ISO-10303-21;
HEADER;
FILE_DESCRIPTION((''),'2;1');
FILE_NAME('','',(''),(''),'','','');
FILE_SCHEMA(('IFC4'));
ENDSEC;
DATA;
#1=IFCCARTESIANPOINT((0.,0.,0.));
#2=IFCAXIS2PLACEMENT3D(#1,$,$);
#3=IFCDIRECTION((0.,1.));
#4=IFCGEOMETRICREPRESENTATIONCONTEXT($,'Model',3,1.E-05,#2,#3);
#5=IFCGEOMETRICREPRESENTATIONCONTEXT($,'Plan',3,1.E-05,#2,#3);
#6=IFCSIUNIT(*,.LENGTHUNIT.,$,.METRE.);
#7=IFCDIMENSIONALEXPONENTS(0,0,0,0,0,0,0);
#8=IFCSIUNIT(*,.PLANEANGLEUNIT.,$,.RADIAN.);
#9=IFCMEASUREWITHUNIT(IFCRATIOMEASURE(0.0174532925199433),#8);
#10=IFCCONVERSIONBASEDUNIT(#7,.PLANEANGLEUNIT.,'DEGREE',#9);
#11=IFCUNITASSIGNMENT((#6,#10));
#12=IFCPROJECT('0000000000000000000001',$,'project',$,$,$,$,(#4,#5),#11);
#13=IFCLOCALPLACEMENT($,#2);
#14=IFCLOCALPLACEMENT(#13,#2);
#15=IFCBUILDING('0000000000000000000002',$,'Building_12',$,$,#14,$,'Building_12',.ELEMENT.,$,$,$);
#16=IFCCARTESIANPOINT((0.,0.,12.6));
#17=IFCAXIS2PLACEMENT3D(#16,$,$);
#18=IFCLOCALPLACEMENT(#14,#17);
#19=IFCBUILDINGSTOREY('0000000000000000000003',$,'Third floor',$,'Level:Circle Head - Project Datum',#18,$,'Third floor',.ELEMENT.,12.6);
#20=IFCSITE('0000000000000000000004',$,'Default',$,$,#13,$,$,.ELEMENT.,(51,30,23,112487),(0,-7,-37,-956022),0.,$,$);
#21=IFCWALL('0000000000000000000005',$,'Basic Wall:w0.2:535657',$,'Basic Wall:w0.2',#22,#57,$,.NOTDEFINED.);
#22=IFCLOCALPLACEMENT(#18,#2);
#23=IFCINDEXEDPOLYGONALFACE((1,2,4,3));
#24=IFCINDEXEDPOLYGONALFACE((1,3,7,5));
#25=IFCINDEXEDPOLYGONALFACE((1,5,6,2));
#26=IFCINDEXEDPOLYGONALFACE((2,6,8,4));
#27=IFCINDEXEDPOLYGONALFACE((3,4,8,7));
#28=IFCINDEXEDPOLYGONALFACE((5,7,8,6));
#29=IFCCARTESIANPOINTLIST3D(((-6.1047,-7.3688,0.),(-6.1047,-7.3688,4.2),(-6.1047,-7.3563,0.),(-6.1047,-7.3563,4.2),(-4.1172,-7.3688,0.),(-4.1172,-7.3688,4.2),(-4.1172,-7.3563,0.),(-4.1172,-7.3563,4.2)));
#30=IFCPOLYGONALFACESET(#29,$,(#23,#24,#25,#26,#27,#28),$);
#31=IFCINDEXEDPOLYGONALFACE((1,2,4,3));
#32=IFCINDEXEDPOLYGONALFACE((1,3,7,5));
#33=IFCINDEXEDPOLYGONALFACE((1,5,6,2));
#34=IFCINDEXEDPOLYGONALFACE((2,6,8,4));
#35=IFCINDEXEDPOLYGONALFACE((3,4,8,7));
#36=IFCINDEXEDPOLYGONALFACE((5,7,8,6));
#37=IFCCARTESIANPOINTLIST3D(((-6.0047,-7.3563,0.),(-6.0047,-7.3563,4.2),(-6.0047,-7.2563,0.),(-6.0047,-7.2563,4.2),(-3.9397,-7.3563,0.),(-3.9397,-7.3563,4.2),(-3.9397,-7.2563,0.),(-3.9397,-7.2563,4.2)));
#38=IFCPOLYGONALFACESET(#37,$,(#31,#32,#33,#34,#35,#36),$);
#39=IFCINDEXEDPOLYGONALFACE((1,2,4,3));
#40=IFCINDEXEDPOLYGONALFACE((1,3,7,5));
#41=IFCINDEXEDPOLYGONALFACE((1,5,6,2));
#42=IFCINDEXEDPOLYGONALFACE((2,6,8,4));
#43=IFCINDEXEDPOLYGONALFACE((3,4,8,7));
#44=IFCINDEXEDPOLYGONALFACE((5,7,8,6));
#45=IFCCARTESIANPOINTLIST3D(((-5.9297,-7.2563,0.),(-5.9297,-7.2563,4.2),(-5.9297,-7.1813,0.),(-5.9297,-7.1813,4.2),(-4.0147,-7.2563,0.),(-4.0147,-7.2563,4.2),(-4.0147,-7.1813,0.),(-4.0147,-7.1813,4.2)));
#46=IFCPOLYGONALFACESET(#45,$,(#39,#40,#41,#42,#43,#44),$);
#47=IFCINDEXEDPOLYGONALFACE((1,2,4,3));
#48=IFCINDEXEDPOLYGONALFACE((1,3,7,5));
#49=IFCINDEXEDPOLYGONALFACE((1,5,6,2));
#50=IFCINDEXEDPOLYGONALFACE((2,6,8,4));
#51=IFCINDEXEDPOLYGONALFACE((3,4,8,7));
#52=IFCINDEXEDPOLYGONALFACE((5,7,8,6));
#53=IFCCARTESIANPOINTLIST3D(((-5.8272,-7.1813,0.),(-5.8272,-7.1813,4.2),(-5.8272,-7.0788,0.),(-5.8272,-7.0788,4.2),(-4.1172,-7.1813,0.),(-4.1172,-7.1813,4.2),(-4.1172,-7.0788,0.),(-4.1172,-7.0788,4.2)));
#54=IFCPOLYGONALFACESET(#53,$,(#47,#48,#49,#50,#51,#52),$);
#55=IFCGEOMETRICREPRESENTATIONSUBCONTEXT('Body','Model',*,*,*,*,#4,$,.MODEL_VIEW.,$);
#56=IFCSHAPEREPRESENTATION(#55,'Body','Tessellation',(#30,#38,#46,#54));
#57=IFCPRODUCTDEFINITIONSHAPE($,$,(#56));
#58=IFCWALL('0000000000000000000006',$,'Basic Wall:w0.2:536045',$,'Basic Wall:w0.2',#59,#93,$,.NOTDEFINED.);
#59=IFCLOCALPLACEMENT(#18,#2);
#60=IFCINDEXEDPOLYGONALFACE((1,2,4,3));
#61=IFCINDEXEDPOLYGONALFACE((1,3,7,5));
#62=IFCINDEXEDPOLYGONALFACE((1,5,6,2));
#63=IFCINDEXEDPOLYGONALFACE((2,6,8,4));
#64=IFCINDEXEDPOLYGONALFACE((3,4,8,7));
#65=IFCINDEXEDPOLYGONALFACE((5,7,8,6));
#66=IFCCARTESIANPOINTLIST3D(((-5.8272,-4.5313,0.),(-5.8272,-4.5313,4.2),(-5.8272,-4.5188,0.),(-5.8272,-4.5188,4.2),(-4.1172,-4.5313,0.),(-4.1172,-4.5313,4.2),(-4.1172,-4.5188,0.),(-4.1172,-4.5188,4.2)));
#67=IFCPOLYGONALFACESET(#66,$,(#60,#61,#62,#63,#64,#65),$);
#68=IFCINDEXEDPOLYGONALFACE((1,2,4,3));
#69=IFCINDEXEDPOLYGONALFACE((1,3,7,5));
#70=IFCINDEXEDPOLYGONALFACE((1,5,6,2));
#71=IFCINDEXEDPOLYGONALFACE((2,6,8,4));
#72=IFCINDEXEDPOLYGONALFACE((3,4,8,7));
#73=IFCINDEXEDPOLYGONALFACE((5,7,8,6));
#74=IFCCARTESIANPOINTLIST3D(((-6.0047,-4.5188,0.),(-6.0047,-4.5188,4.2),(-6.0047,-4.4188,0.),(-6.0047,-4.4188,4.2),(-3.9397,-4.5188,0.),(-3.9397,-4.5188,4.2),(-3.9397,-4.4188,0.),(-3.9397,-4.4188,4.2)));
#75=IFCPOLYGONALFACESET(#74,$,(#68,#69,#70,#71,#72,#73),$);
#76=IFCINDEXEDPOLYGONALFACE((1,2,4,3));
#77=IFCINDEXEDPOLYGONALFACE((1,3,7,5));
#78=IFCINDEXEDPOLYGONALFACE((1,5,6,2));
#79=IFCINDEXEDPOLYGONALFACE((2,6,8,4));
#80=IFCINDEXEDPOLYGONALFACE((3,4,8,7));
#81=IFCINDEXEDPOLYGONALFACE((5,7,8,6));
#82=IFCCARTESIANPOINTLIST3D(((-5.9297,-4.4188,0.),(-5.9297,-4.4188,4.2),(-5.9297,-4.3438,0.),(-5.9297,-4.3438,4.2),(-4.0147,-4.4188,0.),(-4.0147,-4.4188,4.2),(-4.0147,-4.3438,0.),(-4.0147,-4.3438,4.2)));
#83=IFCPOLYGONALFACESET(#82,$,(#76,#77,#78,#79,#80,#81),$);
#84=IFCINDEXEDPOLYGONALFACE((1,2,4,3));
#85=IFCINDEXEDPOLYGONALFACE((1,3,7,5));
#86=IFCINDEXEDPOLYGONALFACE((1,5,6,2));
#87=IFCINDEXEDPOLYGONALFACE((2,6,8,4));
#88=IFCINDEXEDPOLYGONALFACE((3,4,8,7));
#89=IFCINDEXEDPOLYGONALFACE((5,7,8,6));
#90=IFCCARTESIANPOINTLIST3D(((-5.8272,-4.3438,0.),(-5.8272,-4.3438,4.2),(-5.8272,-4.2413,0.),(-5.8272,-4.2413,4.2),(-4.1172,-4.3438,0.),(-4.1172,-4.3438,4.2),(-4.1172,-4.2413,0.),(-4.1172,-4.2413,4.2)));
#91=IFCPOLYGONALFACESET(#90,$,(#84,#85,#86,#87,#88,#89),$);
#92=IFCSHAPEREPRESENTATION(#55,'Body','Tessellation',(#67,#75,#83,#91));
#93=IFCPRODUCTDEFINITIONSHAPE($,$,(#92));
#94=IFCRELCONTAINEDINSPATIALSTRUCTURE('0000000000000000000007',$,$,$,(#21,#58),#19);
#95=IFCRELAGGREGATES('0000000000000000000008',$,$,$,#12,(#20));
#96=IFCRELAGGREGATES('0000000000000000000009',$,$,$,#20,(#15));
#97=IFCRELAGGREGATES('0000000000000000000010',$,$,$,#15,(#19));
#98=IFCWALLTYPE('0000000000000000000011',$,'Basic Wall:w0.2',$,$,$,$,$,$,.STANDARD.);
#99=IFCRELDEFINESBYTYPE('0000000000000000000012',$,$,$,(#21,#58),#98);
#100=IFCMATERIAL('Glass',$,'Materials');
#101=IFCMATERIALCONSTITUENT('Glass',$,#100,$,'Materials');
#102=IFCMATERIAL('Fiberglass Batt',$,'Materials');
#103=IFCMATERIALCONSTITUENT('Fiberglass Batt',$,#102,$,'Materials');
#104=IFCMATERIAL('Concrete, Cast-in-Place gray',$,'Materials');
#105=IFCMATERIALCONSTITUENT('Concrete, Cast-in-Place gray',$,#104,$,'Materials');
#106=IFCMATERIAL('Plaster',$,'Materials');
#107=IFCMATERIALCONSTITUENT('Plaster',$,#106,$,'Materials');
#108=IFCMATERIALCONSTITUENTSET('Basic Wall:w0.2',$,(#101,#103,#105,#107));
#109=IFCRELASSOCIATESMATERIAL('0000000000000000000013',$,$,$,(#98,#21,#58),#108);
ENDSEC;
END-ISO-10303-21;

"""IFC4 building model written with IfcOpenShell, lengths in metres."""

from ifc_helpers import new_model, entity, si_unit, converted_unit, direction, frame, origin, place, context, subcontext, project, spatial, indexed_curve, outline, extrude, material, constituent, constituent_set, type_object, element, save


model = new_model("IFC4")

# Units and contexts
model_context = context("Model", 3, precision=1e-05, world=origin(), true_north=direction((0.0, 1.0)))
plan_context = context("Plan", 3, precision=1e-05, world=origin(), true_north=direction((0.0, 1.0)))
body_context = subcontext(model_context, "Body", "Model", "MODEL_VIEW")
ifc_project = project(units=[si_unit("LENGTHUNIT", "METRE"), converted_unit("PLANEANGLEUNIT", "DEGREE", entity("IfcRatioMeasure", 0.0174532925199433), si_unit("PLANEANGLEUNIT", "RADIAN"), dimensions=[0, 0, 0, 0, 0, 0, 0])], contexts=[model_context, plan_context])

# Site, building, storey
site_placement = place(None, origin())
site = spatial("IfcSite", under=ifc_project, at=site_placement, Name="Default", CompositionType="ELEMENT", RefLatitude=(51, 30, 23, 112487), RefLongitude=(0, -7, -37, -956022), RefElevation=0.0)
building_placement = place(site_placement, origin())
building = spatial("IfcBuilding", under=site, at=building_placement, Name="Building_12", LongName="Building_12", CompositionType="ELEMENT")
storey_placement = place(building_placement, frame((0.0, 0.0, 12.6)))
storey = spatial("IfcBuildingStorey", under=building, at=storey_placement, Name="Third floor", ObjectType="Level:Circle Head - Project Datum", LongName="Third floor", CompositionType="ELEMENT", Elevation=12.6)

# Shared definitions
ifc_material_1 = material(Name="Plaster", Category="Materials")
ifc_material_2 = material(Name="Glass", Category="Materials")

# Shared definitions
ifc_constituent_1 = constituent(ifc_material_2, Name="Glass", Category="Materials")
ifc_material_3 = material(Name="Fiberglass Batt", Category="Materials")
ifc_constituent_2 = constituent(ifc_material_3, Name="Fiberglass Batt", Category="Materials")
ifc_material_4 = material(Name="Concrete, Cast-in-Place gray", Category="Materials")
ifc_constituent_3 = constituent(ifc_material_4, Name="Concrete, Cast-in-Place gray", Category="Materials")
ifc_constituent_4 = constituent(ifc_material_1, Name="Plaster", Category="Materials")
ifc_constituent_set_1 = constituent_set(constituents=[ifc_constituent_1, ifc_constituent_2, ifc_constituent_3, ifc_constituent_4], Name="Basic Wall:w0.2")
wall_type = type_object("IfcWallType", Name="Basic Wall:w0.2", PredefinedType="STANDARD", material=ifc_constituent_set_1)

# Walls
wall_1_placement = place(storey_placement, frame((-5.8272, -7.2238, 0.0)))
element("IfcWall", 1, at=wall_1_placement, inside=storey, type_object=wall_type, material=ifc_constituent_set_1, Name="Basic Wall:w0.2:535657", ObjectType="Basic Wall:w0.2", PredefinedType="NOTDEFINED", context=body_context, shape_type="SweptSolid", body=[
    extrude(outline(indexed_curve([(-0.0063, -0.9938), (0.0062, -0.9938), (0.0063, 0.9938), (-0.0062, 0.9938), (-0.0063, -0.9938)], self_intersect=False)), frame((0.7163, -0.1388, 0.0), z_axis=(0.0, 0.0, 1.0), x_axis=(0.0, 1.0, 0.0)), (0.0, 0.0, 1.0), 4.2),
    extrude(outline(indexed_curve([(-1.0325, -0.05), (1.0325, -0.05), (1.0325, 0.05), (-1.0325, 0.05), (-1.0325, -0.05)], self_intersect=False)), frame((0.855, -0.0825, 0.0)), (0.0, 0.0, 1.0), 4.2),
    extrude(outline(indexed_curve([(-0.9575, -0.0375), (0.9575, -0.0375), (0.9575, 0.0375), (-0.9575, 0.0375), (-0.9575, -0.0375)], self_intersect=False)), frame((0.855, 0.005, 0.0)), (0.0, 0.0, 1.0), 4.2),
    extrude(outline(indexed_curve([(-0.0513, -0.855), (0.0512, -0.855), (0.0513, 0.855), (-0.0512, 0.855), (-0.0513, -0.855)], self_intersect=False)), frame((0.855, 0.0938, 0.0), z_axis=(0.0, 0.0, 1.0), x_axis=(0.0, -1.0, 0.0)), (0.0, 0.0, 1.0), 4.2),
])
wall_2_placement = place(storey_placement, frame((-5.8272, -4.3863, 0.0)))
element("IfcWall", 2, at=wall_2_placement, inside=storey, type_object=wall_type, material=ifc_constituent_set_1, Name="Basic Wall:w0.2:536045", ObjectType="Basic Wall:w0.2", PredefinedType="NOTDEFINED", context=body_context, shape_type="SweptSolid", body=[
    extrude(outline(indexed_curve([(-0.0063, -0.855), (0.0062, -0.855), (0.0063, 0.855), (-0.0062, 0.855), (-0.0063, -0.855)], self_intersect=False)), frame((0.855, -0.1388, 0.0), z_axis=(0.0, 0.0, 1.0), x_axis=(0.0, 1.0, 0.0)), (0.0, 0.0, 1.0), 4.2),
    extrude(outline(indexed_curve([(-1.0325, -0.05), (1.0325, -0.05), (1.0325, 0.05), (-1.0325, 0.05), (-1.0325, -0.05)], self_intersect=False)), frame((0.855, -0.0825, 0.0)), (0.0, 0.0, 1.0), 4.2),
    extrude(outline(indexed_curve([(-0.9575, -0.0375), (0.9575, -0.0375), (0.9575, 0.0375), (-0.9575, 0.0375), (-0.9575, -0.0375)], self_intersect=False)), frame((0.855, 0.005, 0.0)), (0.0, 0.0, 1.0), 4.2),
    extrude(outline(indexed_curve([(-0.0513, -0.855), (0.0512, -0.855), (0.0513, 0.855), (-0.0512, 0.855), (-0.0513, -0.855)], self_intersect=False)), frame((0.855, 0.0937, 0.0), z_axis=(0.0, 0.0, 1.0), x_axis=(0.0, -1.0, 0.0)), (0.0, 0.0, 1.0), 4.2),
])

save(model, "model.ifc")
